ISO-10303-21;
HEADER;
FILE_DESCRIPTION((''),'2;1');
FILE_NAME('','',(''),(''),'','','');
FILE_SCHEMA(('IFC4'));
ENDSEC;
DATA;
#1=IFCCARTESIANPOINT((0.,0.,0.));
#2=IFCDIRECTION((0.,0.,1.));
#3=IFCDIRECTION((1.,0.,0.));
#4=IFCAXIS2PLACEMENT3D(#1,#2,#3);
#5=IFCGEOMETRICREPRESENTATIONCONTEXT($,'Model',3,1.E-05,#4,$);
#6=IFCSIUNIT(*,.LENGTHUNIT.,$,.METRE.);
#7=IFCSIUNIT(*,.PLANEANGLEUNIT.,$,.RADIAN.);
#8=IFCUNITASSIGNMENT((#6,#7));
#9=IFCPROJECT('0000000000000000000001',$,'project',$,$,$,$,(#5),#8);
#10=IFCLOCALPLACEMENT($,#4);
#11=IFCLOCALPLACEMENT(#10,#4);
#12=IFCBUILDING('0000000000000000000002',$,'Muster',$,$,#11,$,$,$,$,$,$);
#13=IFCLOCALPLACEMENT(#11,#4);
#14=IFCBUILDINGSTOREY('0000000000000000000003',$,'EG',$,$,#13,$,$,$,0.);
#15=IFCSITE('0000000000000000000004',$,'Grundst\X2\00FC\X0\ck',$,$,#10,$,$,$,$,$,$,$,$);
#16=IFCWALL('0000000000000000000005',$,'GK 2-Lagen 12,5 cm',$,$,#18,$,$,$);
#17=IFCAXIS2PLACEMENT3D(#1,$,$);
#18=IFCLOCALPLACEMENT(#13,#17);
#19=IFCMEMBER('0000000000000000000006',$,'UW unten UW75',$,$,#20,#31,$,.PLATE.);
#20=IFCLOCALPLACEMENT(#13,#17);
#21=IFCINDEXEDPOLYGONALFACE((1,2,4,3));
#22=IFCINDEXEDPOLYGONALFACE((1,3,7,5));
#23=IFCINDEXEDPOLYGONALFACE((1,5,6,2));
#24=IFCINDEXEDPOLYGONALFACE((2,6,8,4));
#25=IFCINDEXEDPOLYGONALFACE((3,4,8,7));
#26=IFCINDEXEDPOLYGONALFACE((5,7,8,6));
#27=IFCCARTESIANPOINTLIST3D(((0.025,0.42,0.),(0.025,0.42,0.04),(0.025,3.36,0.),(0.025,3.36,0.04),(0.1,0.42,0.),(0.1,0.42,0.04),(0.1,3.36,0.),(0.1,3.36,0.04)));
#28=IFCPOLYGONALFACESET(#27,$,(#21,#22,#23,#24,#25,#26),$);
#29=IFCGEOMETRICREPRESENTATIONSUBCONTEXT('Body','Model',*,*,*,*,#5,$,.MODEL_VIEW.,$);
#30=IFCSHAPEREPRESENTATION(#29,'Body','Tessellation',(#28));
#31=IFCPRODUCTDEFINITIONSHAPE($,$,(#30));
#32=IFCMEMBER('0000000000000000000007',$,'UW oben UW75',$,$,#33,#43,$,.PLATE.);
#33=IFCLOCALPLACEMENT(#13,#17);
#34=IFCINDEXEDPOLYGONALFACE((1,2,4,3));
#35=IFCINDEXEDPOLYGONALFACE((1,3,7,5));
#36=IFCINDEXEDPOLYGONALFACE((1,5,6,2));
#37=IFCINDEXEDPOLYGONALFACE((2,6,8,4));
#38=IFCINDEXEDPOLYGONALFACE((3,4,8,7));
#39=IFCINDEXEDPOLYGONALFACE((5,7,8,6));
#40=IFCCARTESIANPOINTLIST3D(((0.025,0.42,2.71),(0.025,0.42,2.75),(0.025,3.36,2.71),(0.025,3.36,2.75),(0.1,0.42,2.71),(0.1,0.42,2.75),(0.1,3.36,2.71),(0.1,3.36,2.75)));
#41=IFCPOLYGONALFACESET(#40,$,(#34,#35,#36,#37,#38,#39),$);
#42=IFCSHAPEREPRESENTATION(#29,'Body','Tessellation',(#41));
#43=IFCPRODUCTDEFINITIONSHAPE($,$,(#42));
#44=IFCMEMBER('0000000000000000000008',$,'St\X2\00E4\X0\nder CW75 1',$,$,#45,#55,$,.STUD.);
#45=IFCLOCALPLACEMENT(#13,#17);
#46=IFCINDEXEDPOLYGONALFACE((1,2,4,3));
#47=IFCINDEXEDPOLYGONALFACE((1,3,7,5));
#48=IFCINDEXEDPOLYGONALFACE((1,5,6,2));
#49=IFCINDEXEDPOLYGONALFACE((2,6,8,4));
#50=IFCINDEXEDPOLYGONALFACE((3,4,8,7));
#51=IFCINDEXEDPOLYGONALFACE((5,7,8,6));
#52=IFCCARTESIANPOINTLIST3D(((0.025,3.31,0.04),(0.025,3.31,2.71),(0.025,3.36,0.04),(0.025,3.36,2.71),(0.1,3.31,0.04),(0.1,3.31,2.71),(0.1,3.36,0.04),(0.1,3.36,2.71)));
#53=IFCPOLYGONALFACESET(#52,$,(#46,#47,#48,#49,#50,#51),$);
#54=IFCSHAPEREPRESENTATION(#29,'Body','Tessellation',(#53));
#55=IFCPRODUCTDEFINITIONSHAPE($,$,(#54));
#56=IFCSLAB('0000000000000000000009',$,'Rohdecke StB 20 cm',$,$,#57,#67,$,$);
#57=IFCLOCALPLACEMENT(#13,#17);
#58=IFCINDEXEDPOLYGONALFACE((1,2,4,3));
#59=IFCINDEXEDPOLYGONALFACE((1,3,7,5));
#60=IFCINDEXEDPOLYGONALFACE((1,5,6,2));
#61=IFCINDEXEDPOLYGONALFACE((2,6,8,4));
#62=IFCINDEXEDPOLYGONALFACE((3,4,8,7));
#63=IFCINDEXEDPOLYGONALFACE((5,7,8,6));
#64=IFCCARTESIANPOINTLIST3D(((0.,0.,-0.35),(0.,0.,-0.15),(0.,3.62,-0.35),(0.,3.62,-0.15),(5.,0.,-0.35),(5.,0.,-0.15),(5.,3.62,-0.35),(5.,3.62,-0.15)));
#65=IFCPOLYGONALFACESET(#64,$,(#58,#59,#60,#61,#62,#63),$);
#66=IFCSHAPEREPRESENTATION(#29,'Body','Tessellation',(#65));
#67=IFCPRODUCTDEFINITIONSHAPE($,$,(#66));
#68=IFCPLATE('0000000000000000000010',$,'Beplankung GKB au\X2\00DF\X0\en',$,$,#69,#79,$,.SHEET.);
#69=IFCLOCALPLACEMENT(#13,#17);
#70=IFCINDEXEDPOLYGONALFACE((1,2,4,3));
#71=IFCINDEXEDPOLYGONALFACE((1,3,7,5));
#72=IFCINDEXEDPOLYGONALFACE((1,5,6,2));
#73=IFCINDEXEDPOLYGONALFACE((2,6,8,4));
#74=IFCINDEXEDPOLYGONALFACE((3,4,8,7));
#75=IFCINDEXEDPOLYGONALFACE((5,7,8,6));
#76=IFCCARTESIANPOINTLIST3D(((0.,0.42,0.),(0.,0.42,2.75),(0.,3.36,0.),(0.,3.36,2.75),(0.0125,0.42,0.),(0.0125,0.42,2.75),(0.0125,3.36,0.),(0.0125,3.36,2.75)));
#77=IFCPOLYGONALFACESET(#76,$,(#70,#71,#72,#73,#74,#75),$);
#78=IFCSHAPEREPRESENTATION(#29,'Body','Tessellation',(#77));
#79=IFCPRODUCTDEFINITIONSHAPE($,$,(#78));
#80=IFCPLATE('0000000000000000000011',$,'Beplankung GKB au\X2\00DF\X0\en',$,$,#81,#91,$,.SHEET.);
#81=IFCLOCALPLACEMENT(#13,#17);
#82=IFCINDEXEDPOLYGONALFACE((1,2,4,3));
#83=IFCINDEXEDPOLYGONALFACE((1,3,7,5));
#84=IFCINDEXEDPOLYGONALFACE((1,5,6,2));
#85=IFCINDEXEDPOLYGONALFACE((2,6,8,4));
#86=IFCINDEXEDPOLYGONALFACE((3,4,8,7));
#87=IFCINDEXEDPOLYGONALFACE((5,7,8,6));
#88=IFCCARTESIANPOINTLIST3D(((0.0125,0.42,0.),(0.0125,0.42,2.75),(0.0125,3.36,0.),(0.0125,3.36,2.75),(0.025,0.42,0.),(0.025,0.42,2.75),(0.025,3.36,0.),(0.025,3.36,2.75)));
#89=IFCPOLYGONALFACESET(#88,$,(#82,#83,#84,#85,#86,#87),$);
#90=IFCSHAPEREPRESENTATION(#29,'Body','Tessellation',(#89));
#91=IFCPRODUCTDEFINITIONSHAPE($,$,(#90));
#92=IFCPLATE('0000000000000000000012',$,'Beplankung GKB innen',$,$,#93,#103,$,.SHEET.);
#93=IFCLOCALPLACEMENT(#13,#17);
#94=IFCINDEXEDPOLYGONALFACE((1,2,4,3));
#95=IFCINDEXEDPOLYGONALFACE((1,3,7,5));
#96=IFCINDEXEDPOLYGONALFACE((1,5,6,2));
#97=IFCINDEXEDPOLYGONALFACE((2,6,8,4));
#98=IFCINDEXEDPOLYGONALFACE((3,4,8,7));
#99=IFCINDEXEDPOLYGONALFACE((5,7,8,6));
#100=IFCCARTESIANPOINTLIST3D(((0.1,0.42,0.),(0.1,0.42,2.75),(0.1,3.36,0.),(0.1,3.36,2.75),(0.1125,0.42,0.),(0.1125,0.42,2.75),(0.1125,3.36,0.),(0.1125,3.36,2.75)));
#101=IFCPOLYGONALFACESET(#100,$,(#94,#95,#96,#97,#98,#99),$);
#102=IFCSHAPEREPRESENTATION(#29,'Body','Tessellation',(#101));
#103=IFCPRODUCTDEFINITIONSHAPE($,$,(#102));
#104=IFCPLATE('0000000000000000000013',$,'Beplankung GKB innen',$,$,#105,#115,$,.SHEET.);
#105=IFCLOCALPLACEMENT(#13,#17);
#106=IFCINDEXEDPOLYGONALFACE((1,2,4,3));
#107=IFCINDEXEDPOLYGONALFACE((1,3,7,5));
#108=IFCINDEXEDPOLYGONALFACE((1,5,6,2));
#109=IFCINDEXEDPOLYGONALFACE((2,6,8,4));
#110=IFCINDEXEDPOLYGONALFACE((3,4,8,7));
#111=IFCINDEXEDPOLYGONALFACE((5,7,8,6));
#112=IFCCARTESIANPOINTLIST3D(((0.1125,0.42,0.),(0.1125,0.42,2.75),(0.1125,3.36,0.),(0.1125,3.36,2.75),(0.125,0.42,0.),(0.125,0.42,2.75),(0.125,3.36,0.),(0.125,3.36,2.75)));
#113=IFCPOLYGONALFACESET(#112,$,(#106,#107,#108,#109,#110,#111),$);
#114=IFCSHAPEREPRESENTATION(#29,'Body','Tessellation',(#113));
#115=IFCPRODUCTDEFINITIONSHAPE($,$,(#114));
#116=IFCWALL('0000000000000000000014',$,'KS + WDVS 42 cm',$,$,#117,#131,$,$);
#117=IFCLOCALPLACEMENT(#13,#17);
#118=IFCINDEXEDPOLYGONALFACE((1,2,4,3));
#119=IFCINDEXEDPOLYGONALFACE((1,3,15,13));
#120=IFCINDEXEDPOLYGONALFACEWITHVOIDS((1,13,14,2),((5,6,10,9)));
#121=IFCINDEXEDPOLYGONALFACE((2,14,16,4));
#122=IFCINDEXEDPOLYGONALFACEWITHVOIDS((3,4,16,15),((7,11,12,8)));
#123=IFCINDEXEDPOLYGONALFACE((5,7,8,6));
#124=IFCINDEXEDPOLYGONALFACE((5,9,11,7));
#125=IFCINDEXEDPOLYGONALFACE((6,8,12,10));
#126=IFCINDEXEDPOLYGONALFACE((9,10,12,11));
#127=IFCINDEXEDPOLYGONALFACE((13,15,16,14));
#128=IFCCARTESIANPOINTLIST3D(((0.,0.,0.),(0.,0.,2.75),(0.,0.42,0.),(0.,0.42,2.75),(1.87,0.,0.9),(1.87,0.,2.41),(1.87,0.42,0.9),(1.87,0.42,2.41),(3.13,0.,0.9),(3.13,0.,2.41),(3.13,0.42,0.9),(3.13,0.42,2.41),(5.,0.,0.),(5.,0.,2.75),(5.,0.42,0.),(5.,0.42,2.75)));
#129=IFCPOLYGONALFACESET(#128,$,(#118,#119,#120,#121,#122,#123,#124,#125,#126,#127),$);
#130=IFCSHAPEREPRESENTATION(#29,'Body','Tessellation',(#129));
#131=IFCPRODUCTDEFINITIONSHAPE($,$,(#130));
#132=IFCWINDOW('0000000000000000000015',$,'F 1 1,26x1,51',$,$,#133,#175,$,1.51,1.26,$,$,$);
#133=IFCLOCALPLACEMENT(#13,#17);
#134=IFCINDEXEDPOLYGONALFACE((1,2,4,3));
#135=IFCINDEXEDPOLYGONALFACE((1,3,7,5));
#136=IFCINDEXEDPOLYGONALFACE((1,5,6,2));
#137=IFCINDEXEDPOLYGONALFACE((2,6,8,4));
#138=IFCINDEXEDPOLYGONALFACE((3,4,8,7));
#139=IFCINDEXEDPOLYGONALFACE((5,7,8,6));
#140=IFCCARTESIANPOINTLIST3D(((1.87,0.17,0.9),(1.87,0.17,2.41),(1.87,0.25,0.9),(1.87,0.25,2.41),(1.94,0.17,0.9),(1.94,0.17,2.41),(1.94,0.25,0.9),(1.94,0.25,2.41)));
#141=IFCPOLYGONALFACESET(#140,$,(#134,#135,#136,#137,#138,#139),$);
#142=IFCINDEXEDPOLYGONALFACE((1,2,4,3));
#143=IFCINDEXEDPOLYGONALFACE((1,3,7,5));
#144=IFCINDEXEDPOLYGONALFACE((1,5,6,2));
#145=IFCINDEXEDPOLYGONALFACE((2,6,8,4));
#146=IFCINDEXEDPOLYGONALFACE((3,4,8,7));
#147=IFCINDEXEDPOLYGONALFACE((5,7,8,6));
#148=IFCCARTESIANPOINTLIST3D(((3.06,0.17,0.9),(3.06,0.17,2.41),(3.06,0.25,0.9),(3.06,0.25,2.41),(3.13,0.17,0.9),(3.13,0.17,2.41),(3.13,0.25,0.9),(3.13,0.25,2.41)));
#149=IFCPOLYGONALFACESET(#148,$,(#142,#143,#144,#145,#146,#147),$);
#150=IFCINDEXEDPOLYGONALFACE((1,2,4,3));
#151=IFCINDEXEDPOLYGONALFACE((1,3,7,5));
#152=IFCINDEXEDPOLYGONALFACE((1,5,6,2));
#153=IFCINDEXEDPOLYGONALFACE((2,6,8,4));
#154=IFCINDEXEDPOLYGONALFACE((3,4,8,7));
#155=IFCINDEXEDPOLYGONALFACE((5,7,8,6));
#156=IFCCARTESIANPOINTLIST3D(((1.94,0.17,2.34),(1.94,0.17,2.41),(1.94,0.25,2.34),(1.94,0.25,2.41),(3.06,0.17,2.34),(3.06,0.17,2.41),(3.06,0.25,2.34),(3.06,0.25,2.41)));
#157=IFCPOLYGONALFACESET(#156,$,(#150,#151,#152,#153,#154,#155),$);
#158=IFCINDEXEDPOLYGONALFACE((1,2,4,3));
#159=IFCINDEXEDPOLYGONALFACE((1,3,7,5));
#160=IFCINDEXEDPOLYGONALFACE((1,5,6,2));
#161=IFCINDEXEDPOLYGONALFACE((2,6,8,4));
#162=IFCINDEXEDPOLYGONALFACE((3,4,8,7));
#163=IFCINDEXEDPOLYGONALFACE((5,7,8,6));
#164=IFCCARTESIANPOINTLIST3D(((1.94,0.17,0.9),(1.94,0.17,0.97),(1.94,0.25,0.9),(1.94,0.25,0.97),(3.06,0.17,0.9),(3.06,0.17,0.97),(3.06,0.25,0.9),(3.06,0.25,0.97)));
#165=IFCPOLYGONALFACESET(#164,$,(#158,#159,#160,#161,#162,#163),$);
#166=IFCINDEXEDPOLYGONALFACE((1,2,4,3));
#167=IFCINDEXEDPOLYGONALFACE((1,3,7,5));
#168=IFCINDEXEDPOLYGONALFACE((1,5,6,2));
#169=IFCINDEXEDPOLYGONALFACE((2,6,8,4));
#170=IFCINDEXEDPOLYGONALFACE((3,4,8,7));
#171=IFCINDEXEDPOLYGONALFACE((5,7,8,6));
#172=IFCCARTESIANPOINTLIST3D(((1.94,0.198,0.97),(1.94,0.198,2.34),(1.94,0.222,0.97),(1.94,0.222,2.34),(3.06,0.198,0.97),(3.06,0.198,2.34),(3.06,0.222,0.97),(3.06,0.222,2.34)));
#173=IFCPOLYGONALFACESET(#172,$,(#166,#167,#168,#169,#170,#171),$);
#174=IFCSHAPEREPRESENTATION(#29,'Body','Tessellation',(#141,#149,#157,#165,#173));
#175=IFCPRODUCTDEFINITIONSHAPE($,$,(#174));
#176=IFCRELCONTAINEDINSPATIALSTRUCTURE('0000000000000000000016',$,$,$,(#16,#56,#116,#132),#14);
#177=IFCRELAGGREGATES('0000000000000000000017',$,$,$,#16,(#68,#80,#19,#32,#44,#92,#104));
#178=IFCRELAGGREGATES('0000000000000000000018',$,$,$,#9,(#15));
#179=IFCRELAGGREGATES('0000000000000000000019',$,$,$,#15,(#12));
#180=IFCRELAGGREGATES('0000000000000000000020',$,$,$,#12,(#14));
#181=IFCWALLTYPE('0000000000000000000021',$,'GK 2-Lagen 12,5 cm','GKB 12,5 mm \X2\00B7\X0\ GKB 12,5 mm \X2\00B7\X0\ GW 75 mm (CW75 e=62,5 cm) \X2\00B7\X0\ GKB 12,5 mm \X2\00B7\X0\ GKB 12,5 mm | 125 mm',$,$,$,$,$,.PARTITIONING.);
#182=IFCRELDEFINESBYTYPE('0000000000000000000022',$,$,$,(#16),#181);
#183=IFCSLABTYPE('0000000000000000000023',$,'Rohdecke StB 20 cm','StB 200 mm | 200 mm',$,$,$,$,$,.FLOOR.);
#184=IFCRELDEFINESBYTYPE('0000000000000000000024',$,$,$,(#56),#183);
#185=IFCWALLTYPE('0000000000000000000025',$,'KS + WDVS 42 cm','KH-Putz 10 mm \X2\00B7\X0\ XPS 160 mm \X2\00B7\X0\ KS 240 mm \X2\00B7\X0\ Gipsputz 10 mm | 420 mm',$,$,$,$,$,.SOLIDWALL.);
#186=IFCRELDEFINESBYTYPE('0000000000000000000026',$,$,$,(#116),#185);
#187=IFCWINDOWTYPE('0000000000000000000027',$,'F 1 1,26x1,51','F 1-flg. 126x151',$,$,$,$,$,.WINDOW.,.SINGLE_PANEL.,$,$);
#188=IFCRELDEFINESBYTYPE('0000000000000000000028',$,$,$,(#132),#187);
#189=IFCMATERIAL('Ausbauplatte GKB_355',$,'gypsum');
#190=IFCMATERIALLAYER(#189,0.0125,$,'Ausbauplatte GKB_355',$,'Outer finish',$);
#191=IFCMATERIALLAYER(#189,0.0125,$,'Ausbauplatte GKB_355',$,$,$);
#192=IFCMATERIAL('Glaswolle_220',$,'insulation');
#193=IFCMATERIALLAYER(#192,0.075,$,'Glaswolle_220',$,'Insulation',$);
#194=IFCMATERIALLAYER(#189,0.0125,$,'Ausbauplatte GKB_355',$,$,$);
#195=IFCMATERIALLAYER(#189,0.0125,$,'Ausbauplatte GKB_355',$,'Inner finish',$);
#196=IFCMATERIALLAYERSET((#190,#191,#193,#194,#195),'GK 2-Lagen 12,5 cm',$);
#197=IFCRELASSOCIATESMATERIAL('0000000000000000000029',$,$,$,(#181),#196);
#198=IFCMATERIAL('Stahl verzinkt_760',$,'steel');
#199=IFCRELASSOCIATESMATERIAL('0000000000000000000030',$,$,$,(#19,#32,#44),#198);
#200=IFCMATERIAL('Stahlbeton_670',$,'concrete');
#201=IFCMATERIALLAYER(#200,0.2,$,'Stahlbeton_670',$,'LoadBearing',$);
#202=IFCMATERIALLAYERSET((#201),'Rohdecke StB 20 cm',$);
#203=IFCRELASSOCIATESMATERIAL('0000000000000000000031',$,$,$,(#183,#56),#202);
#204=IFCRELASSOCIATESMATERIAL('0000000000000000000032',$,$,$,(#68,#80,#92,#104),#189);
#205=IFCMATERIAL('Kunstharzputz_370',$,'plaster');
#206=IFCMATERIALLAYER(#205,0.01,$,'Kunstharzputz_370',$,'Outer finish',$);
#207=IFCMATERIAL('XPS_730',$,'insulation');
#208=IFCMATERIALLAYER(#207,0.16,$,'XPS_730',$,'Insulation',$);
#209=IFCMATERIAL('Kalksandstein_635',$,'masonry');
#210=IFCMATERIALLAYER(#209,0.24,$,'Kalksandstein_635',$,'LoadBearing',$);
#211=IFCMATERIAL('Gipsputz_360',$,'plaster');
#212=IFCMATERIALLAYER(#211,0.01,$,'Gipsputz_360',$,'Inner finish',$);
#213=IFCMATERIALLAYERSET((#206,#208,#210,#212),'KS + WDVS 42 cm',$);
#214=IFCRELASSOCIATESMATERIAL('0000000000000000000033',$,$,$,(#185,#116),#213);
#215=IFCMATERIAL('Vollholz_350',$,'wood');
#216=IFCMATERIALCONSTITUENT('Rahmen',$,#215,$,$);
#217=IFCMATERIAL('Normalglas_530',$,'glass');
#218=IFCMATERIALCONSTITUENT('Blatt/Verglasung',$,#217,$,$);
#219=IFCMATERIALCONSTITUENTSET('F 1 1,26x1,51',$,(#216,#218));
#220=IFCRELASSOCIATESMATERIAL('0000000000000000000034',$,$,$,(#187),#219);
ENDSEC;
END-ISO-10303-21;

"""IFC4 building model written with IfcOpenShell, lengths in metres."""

from ifc_helpers import new_model, si_unit, frame, frame_2d, origin, origin_with_axes, place, context, subcontext, project, spatial, rectangle, extrude, source, transform, mapped, material, layer, layer_set, layer_usage, constituent, constituent_set, type_object, type_shapes, element, fill, aggregate, save


model = new_model("IFC4")

# Units and contexts
model_context = context("Model", 3, precision=1e-05, world=origin_with_axes())
body_context = subcontext(model_context, "Body", "Model", "MODEL_VIEW")
ifc_project = project(units=[si_unit("LENGTHUNIT", "METRE"), si_unit("PLANEANGLEUNIT", "RADIAN")], contexts=[model_context])

# Site, building, storey
site_placement = place(None, origin_with_axes())
site = spatial("IfcSite", under=ifc_project, at=site_placement, Name="Grundstück")
building_placement = place(site_placement, origin_with_axes())
building = spatial("IfcBuilding", under=site, at=building_placement, Name="Muster")
storey_placement = place(building_placement, origin_with_axes())
storey = spatial("IfcBuildingStorey", under=building, at=storey_placement, Name="EG", Elevation=0.0)

# Wall, members
ifc_material_1 = material(Name="Ausbauplatte GKB_355", Category="gypsum")
ifc_layer_1 = layer(ifc_material_1, 0.0125, Name="Ausbauplatte GKB_355", Category="Outer finish")
ifc_layer_2 = layer(ifc_material_1, 0.0125, Name="Ausbauplatte GKB_355")
ifc_material_2 = material(Name="Glaswolle_220", Category="insulation")
ifc_layer_3 = layer(ifc_material_2, 0.075, Name="Glaswolle_220", Category="Insulation")
ifc_layer_4 = layer(ifc_material_1, 0.0125, Name="Ausbauplatte GKB_355")
ifc_layer_5 = layer(ifc_material_1, 0.0125, Name="Ausbauplatte GKB_355", Category="Inner finish")
ifc_layer_set_1 = layer_set([ifc_layer_1, ifc_layer_2, ifc_layer_3, ifc_layer_4, ifc_layer_5], Name="GK 2-Lagen 12,5 cm")
wall_type_1 = type_object("IfcWallType", Name="GK 2-Lagen 12,5 cm", Description="GKB 12,5 mm · GKB 12,5 mm · GW 75 mm (CW75 e=62,5 cm) · GKB 12,5 mm · GKB 12,5 mm | 125 mm", PredefinedType="PARTITIONING", material=ifc_layer_set_1)
wall_1_placement = place(storey_placement, frame((0.0, 3.36, 0.0), z_axis=(0.0, 0.0, 1.0), x_axis=(0.0, -1.0, 0.0)))
wall_1 = element("IfcWall", 1, at=wall_1_placement, inside=storey, type_object=wall_type_1, Name="GK 2-Lagen 12,5 cm")
ifc_material_3 = material(Name="Stahl verzinkt_760", Category="steel")
member_1_placement = place(wall_1_placement, origin_with_axes())
member_1 = element("IfcMember", 2, at=member_1_placement, material=ifc_material_3, Name="UW unten UW75", PredefinedType="PLATE", context=body_context, shape_type="SweptSolid", body=[
    extrude(rectangle(XDim=2.94, YDim=0.075, at=frame_2d((1.47, 0.0625))), origin(), (0.0, 0.0, 1.0), 0.04),
])
member_2_placement = place(wall_1_placement, origin_with_axes())
member_2 = element("IfcMember", 3, at=member_2_placement, material=ifc_material_3, Name="UW oben UW75", PredefinedType="PLATE", context=body_context, shape_type="SweptSolid", body=[
    extrude(rectangle(XDim=2.94, YDim=0.075, at=frame_2d((1.47, 0.0625))), frame((0.0, 0.0, 2.71)), (0.0, 0.0, 1.0), 0.04),
])
member_3_placement = place(wall_1_placement, origin_with_axes())
member_3 = element("IfcMember", 4, at=member_3_placement, material=ifc_material_3, Name="Ständer CW75 1", PredefinedType="STUD", context=body_context, shape_type="SweptSolid", body=[
    extrude(rectangle(XDim=0.05, YDim=0.075, at=frame_2d((0.025, 0.0625))), frame((0.0, 0.0, 0.04)), (0.0, 0.0, 1.0), 2.67),
])

# Slab
ifc_material_4 = material(Name="Stahlbeton_670", Category="concrete")
ifc_layer_6 = layer(ifc_material_4, 0.2, Name="Stahlbeton_670", Category="LoadBearing")
ifc_layer_set_2 = layer_set([ifc_layer_6], Name="Rohdecke StB 20 cm")
ifc_layer_usage_1 = layer_usage(ifc_layer_set_2, "AXIS3", "NEGATIVE", 0.0)
slab_type = type_object("IfcSlabType", Name="Rohdecke StB 20 cm", Description="StB 200 mm | 200 mm", PredefinedType="FLOOR", material=ifc_layer_set_2)
slab_placement = place(storey_placement, frame((0.0, 0.0, -0.15), z_axis=(0.0, 0.0, 1.0), x_axis=(1.0, 0.0, 0.0)))
element("IfcSlab", 5, at=slab_placement, inside=storey, type_object=slab_type, material=ifc_layer_usage_1, Name="Rohdecke StB 20 cm", context=body_context, shape_type="SweptSolid", body=[
    extrude(rectangle(XDim=5.0, YDim=3.62, at=frame_2d((2.5, 1.81))), origin(), (0.0, 0.0, -1.0), 0.2),
])

# Plates
plate_1_placement = place(wall_1_placement, origin_with_axes())
plate_1 = element("IfcPlate", 6, at=plate_1_placement, material=ifc_material_1, Name="Beplankung GKB außen", PredefinedType="SHEET", context=body_context, shape_type="SweptSolid", body=[
    extrude(rectangle(XDim=2.94, YDim=0.0125, at=frame_2d((1.47, 0.0063))), origin(), (0.0, 0.0, 1.0), 2.75),
])
plate_2_placement = place(wall_1_placement, origin_with_axes())
plate_2 = element("IfcPlate", 7, at=plate_2_placement, material=ifc_material_1, Name="Beplankung GKB außen", PredefinedType="SHEET", context=body_context, shape_type="SweptSolid", body=[
    extrude(rectangle(XDim=2.94, YDim=0.0125, at=frame_2d((1.47, 0.0188))), origin(), (0.0, 0.0, 1.0), 2.75),
])
plate_3_placement = place(wall_1_placement, origin_with_axes())
plate_3 = element("IfcPlate", 8, at=plate_3_placement, material=ifc_material_1, Name="Beplankung GKB innen", PredefinedType="SHEET", context=body_context, shape_type="SweptSolid", body=[
    extrude(rectangle(XDim=2.94, YDim=0.0125, at=frame_2d((1.47, 0.1063))), origin(), (0.0, 0.0, 1.0), 2.75),
])
plate_4_placement = place(wall_1_placement, origin_with_axes())
plate_4 = element("IfcPlate", 9, at=plate_4_placement, material=ifc_material_1, Name="Beplankung GKB innen", PredefinedType="SHEET", context=body_context, shape_type="SweptSolid", body=[
    extrude(rectangle(XDim=2.94, YDim=0.0125, at=frame_2d((1.47, 0.1187))), origin(), (0.0, 0.0, 1.0), 2.75),
])

# Wall, opening, window
ifc_material_5 = material(Name="Kunstharzputz_370", Category="plaster")
ifc_layer_7 = layer(ifc_material_5, 0.01, Name="Kunstharzputz_370", Category="Outer finish")
ifc_material_6 = material(Name="XPS_730", Category="insulation")
ifc_layer_8 = layer(ifc_material_6, 0.16, Name="XPS_730", Category="Insulation")
ifc_material_7 = material(Name="Kalksandstein_635", Category="masonry")
ifc_layer_9 = layer(ifc_material_7, 0.24, Name="Kalksandstein_635", Category="LoadBearing")
ifc_material_8 = material(Name="Gipsputz_360", Category="plaster")
ifc_layer_10 = layer(ifc_material_8, 0.01, Name="Gipsputz_360", Category="Inner finish")
ifc_layer_set_3 = layer_set([ifc_layer_7, ifc_layer_8, ifc_layer_9, ifc_layer_10], Name="KS + WDVS 42 cm")
ifc_layer_usage_2 = layer_usage(ifc_layer_set_3, "AXIS2", "POSITIVE", 0.0)
wall_type_2 = type_object("IfcWallType", Name="KS + WDVS 42 cm", Description="KH-Putz 10 mm · XPS 160 mm · KS 240 mm · Gipsputz 10 mm | 420 mm", PredefinedType="SOLIDWALL", material=ifc_layer_set_3)
wall_2_placement = place(storey_placement, origin_with_axes())
wall_2 = element("IfcWall", 10, at=wall_2_placement, inside=storey, type_object=wall_type_2, material=ifc_layer_usage_2, Name="KS + WDVS 42 cm", context=body_context, shape_type="SweptSolid", body=[
    extrude(rectangle(XDim=5.0, YDim=0.42, at=frame_2d((2.5, 0.21))), origin(), (0.0, 0.0, 1.0), 2.75),
])
opening_1_placement = place(wall_2_placement, frame((1.87, 0.0, 0.9), z_axis=(0.0, 0.0, 1.0), x_axis=(1.0, 0.0, 0.0)))
opening_1 = element("IfcOpeningElement", 11, at=opening_1_placement, cuts=wall_2, PredefinedType="OPENING", context=body_context, shape_type="SweptSolid", body=[
    extrude(rectangle(XDim=1.26, YDim=0.44, at=frame_2d((0.63, 0.21))), origin(), (0.0, 0.0, 1.0), 1.51),
])
ifc_material_9 = material(Name="Vollholz_350", Category="wood")
ifc_constituent_1 = constituent(ifc_material_9, Name="Rahmen")
ifc_material_10 = material(Name="Normalglas_530", Category="glass")
ifc_constituent_2 = constituent(ifc_material_10, Name="Blatt/Verglasung")
ifc_constituent_set_1 = constituent_set(constituents=[ifc_constituent_1, ifc_constituent_2], Name="F 1 1,26x1,51")
window_type = type_object("IfcWindowType", Name="F 1 1,26x1,51", Description="F 1-flg. 126x151", PartitioningType="SINGLE_PANEL", PredefinedType="WINDOW", material=ifc_constituent_set_1)
shared_shape_1 = source(origin(), body_context, "Body", "SweptSolid", [
    extrude(rectangle(XDim=0.07, YDim=0.08, at=frame_2d((0.035, 0.04))), origin(), (0.0, 0.0, 1.0), 1.51),
    extrude(rectangle(XDim=0.07, YDim=0.08, at=frame_2d((1.225, 0.04))), origin(), (0.0, 0.0, 1.0), 1.51),
    extrude(rectangle(XDim=1.12, YDim=0.08, at=frame_2d((0.63, 0.04))), frame((0.0, 0.0, 1.44)), (0.0, 0.0, 1.0), 0.07),
    extrude(rectangle(XDim=1.12, YDim=0.08, at=frame_2d((0.63, 0.04))), origin(), (0.0, 0.0, 1.0), 0.07),
    extrude(rectangle(XDim=1.12, YDim=0.024, at=frame_2d((0.63, 0.04))), frame((0.0, 0.0, 0.07)), (0.0, 0.0, 1.0), 1.37),
])
type_shapes(window_type, [shared_shape_1])
window_placement = place(opening_1_placement, origin_with_axes())
window = element("IfcWindow", 12, at=window_placement, inside=storey, type_object=window_type, Name="F 1 1,26x1,51", OverallHeight=1.51, OverallWidth=1.26, context=body_context, shape_type="MappedRepresentation", body=[
    mapped(shared_shape_1, transform((0.0, 0.17, 0.0))),
])
fill(opening_1, window)

aggregate(wall_1, [plate_1, plate_2, member_1, member_2, member_3, plate_3, plate_4])

save(model, "model.ifc")
